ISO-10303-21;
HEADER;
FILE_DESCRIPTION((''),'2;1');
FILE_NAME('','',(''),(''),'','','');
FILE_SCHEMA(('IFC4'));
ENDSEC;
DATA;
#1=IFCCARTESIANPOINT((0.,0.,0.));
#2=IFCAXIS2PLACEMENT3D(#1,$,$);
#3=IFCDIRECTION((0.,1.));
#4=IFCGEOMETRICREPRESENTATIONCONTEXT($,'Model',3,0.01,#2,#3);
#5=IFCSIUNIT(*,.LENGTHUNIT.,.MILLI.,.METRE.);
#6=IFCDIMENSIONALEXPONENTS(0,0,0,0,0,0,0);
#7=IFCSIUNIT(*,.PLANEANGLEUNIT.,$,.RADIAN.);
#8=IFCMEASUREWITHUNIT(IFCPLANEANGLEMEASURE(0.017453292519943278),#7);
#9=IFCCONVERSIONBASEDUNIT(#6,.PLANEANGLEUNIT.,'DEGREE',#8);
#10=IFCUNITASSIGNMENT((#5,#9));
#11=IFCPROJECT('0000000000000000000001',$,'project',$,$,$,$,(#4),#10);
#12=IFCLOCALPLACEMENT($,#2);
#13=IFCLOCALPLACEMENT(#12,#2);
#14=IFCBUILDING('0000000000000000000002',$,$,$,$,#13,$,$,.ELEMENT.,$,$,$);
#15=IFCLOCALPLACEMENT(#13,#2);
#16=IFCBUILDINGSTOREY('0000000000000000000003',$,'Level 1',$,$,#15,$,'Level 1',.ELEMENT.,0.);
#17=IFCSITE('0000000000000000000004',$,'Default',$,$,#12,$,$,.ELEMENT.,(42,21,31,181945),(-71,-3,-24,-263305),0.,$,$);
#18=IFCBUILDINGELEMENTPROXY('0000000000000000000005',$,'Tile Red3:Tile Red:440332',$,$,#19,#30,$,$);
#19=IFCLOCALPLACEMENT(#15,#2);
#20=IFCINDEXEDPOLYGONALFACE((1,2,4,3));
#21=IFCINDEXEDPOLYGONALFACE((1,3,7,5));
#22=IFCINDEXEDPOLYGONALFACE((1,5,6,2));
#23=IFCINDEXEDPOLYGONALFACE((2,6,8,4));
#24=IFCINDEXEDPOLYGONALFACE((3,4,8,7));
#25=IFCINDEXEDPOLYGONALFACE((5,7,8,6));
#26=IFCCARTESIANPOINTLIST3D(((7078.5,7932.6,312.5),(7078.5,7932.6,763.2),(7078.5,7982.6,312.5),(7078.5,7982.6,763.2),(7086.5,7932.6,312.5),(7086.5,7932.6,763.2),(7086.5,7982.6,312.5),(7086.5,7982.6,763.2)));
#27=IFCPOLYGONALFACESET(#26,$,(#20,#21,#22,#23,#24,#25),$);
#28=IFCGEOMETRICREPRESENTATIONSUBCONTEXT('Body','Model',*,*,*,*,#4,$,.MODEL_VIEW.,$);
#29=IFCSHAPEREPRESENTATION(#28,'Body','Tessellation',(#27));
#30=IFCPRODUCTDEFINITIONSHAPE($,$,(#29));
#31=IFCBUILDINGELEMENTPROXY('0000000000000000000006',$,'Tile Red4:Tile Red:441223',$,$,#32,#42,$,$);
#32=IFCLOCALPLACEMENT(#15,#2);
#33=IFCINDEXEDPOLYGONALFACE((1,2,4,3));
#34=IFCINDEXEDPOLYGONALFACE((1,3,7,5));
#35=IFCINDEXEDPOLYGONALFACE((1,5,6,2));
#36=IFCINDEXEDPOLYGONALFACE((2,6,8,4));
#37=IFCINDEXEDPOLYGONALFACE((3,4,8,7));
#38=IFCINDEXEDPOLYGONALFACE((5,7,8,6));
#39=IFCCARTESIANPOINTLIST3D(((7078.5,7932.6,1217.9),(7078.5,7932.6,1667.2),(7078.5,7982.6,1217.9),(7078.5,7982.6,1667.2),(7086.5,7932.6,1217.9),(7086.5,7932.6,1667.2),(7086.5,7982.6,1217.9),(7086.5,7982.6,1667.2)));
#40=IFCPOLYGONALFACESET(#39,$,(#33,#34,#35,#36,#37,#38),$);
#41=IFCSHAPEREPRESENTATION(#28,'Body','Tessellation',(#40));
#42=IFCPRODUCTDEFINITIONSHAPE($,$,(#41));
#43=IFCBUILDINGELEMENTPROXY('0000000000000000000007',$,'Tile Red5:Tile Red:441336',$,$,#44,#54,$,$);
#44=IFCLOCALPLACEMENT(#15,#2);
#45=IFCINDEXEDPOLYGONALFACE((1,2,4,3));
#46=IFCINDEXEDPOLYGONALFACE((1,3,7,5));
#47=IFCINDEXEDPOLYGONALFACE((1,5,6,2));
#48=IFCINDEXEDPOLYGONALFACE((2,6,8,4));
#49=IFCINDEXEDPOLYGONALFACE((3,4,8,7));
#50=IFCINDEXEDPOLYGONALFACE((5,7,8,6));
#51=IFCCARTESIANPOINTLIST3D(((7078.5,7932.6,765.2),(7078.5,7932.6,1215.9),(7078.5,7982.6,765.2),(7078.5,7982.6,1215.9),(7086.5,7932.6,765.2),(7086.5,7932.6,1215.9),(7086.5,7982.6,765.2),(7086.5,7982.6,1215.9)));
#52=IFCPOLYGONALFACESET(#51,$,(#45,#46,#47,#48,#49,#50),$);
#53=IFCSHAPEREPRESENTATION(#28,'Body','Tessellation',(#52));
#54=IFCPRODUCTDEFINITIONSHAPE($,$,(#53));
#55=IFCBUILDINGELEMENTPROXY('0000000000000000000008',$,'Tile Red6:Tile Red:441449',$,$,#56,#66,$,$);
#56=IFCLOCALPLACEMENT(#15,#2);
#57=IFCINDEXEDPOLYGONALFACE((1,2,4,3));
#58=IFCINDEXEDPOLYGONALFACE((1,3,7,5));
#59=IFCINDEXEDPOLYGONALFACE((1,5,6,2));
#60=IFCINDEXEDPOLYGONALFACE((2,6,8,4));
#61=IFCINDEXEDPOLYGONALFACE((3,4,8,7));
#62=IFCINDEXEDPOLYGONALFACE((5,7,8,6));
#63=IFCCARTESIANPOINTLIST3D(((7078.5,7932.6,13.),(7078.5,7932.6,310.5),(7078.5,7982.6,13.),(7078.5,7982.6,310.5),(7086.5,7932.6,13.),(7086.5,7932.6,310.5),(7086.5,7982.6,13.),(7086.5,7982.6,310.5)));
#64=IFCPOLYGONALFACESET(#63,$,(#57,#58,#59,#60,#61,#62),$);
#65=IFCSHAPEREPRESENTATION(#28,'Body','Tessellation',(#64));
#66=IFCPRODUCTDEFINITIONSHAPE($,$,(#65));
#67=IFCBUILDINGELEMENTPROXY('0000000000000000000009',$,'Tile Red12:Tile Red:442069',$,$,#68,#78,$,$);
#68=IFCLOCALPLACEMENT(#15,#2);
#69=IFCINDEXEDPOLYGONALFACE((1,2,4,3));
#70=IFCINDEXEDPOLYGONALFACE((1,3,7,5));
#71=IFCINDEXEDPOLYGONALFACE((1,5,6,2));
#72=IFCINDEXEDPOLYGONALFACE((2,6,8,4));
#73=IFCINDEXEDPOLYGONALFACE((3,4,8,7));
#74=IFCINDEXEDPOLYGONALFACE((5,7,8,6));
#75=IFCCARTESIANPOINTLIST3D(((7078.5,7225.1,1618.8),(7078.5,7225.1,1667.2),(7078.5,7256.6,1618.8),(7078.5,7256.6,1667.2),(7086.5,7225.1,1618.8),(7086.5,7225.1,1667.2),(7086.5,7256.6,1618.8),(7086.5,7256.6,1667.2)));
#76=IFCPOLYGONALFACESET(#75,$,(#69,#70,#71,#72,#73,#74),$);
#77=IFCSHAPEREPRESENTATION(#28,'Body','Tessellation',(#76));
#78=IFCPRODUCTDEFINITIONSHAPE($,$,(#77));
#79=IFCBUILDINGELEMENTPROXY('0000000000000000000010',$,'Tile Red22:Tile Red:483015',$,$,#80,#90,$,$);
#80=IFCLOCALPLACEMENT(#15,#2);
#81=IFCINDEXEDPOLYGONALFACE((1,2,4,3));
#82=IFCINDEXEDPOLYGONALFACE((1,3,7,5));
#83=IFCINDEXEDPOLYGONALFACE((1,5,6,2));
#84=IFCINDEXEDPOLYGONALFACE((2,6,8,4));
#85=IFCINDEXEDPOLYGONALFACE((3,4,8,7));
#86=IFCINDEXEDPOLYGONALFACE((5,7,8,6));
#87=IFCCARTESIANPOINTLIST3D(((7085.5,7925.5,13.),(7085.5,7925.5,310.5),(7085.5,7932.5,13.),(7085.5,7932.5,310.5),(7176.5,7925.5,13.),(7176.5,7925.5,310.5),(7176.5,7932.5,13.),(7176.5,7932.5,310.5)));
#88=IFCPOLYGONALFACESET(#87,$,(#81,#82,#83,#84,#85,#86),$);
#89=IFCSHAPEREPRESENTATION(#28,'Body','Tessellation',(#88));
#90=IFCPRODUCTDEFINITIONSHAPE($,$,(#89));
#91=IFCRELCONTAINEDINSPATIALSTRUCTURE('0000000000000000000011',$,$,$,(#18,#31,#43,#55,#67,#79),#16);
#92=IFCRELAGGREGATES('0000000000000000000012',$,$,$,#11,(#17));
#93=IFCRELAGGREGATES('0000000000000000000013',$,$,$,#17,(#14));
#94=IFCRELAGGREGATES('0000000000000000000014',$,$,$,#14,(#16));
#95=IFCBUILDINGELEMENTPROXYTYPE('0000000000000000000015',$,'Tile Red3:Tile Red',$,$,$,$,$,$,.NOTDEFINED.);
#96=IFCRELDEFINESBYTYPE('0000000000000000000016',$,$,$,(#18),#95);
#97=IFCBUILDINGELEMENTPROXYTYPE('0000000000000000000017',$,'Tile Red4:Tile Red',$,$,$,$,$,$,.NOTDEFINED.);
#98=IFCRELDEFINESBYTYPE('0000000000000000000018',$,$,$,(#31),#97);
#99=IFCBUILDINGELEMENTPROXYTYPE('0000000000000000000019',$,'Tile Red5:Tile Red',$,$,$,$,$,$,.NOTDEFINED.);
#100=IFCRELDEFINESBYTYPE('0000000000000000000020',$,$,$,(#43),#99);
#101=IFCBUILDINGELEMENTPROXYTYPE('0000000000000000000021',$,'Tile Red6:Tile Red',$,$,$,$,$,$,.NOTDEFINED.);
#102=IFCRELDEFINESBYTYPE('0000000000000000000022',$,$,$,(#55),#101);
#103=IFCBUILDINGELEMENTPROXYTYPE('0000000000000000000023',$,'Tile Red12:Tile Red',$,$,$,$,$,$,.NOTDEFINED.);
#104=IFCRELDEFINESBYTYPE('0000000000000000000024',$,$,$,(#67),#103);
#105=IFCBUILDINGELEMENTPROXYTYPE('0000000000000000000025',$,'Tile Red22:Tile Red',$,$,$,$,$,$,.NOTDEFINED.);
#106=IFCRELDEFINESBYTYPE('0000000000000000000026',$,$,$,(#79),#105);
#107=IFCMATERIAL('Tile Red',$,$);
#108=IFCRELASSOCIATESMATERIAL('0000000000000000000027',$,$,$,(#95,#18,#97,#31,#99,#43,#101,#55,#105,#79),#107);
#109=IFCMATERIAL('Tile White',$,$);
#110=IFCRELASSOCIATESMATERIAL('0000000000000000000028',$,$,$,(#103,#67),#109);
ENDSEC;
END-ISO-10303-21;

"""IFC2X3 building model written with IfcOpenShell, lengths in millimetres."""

from ifc_helpers import new_model, entity, si_unit, converted_unit, direction, frame, frame_2d, origin, origin_2d_with_axis, place, context, subcontext, project, spatial, rectangle, extrude, source, transform, mapped, material, type_object, type_shapes, element, save


model = new_model("IFC2X3")

# Units and contexts
model_context = context("Model", 3, precision=0.01, world=origin(), true_north=direction((0.0, 1.0)))
body_context = subcontext(model_context, "Body", "Model", "MODEL_VIEW")
ifc_project = project(units=[si_unit("LENGTHUNIT", "METRE", prefix="MILLI"), converted_unit("PLANEANGLEUNIT", "DEGREE", entity("IfcPlaneAngleMeasure", 0.017453292519943278), si_unit("PLANEANGLEUNIT", "RADIAN"), dimensions=[0, 0, 0, 0, 0, 0, 0])], contexts=[model_context])

# Site, building, storey
site_placement = place(None, origin())
site = spatial("IfcSite", under=ifc_project, at=site_placement, Name="Default", CompositionType="ELEMENT", RefLatitude=(42, 21, 31, 181945), RefLongitude=(-71, -3, -24, -263305), RefElevation=0.0)
building_placement = place(site_placement, origin())
building = spatial("IfcBuilding", under=site, at=building_placement, CompositionType="ELEMENT")
storey_placement = place(building_placement, origin())
storey = spatial("IfcBuildingStorey", under=building, at=storey_placement, Name="Level 1", LongName="Level 1", CompositionType="ELEMENT", Elevation=0.0)

# Building element proxies
ifc_material_1 = material(Name="Tile Red")
building_element_proxy_type_1 = type_object("IfcBuildingElementProxyType", Name="Tile Red3:Tile Red", PredefinedType="NOTDEFINED", material=ifc_material_1)
shared_shape_1 = source(origin(), body_context, "Body", "SweptSolid", [
    extrude(rectangle(XDim=8.0, YDim=50.0, at=origin_2d_with_axis()), frame((7082.5, 7957.6, 312.5)), (0.0, 0.0, 1.0), 450.7),
])
type_shapes(building_element_proxy_type_1, [shared_shape_1])
proxy_1_placement = place(storey_placement, origin())
element("IfcBuildingElementProxy", 1, at=proxy_1_placement, inside=storey, type_object=building_element_proxy_type_1, material=ifc_material_1, Name="Tile Red3:Tile Red:440332", context=body_context, shape_type="MappedRepresentation", body=[
    mapped(shared_shape_1, transform((0.0, 0.0, 0.0), scale=1.0)),
])
building_element_proxy_type_2 = type_object("IfcBuildingElementProxyType", Name="Tile Red4:Tile Red", PredefinedType="NOTDEFINED", material=ifc_material_1)
shared_shape_2 = source(origin(), body_context, "Body", "SweptSolid", [
    extrude(rectangle(XDim=8.0, YDim=50.0, at=origin_2d_with_axis()), frame((7082.5, 7957.6, 1217.9)), (0.0, 0.0, 1.0), 449.3),
])
type_shapes(building_element_proxy_type_2, [shared_shape_2])
proxy_2_placement = place(storey_placement, origin())
element("IfcBuildingElementProxy", 2, at=proxy_2_placement, inside=storey, type_object=building_element_proxy_type_2, material=ifc_material_1, Name="Tile Red4:Tile Red:441223", context=body_context, shape_type="MappedRepresentation", body=[
    mapped(shared_shape_2, transform((0.0, 0.0, 0.0), scale=1.0)),
])
building_element_proxy_type_3 = type_object("IfcBuildingElementProxyType", Name="Tile Red5:Tile Red", PredefinedType="NOTDEFINED", material=ifc_material_1)
shared_shape_3 = source(origin(), body_context, "Body", "SweptSolid", [
    extrude(rectangle(XDim=8.0, YDim=50.0, at=origin_2d_with_axis()), frame((7082.5, 7957.6, 765.2)), (0.0, 0.0, 1.0), 450.7),
])
type_shapes(building_element_proxy_type_3, [shared_shape_3])
proxy_3_placement = place(storey_placement, origin())
element("IfcBuildingElementProxy", 3, at=proxy_3_placement, inside=storey, type_object=building_element_proxy_type_3, material=ifc_material_1, Name="Tile Red5:Tile Red:441336", context=body_context, shape_type="MappedRepresentation", body=[
    mapped(shared_shape_3, transform((0.0, 0.0, 0.0), scale=1.0)),
])
building_element_proxy_type_4 = type_object("IfcBuildingElementProxyType", Name="Tile Red6:Tile Red", PredefinedType="NOTDEFINED", material=ifc_material_1)
shared_shape_4 = source(origin(), body_context, "Body", "SweptSolid", [
    extrude(rectangle(XDim=8.0, YDim=50.0, at=origin_2d_with_axis()), frame((7082.5, 7957.6, 13.0)), (0.0, 0.0, 1.0), 297.5),
])
type_shapes(building_element_proxy_type_4, [shared_shape_4])
proxy_4_placement = place(storey_placement, origin())
element("IfcBuildingElementProxy", 4, at=proxy_4_placement, inside=storey, type_object=building_element_proxy_type_4, material=ifc_material_1, Name="Tile Red6:Tile Red:441449", context=body_context, shape_type="MappedRepresentation", body=[
    mapped(shared_shape_4, transform((0.0, 0.0, 0.0), scale=1.0)),
])
ifc_material_2 = material(Name="Tile White")
building_element_proxy_type_5 = type_object("IfcBuildingElementProxyType", Name="Tile Red12:Tile Red", PredefinedType="NOTDEFINED", material=ifc_material_2)
shared_shape_5 = source(origin(), body_context, "Body", "SweptSolid", [
    extrude(rectangle(XDim=8.0, YDim=31.5, at=frame_2d((0.0, 0.0), x_axis=(1.0, 0.0))), frame((7082.5, 7240.9, 1618.8)), (0.0, 0.0, 1.0), 48.4),
])
type_shapes(building_element_proxy_type_5, [shared_shape_5])
proxy_5_placement = place(storey_placement, origin())
element("IfcBuildingElementProxy", 5, at=proxy_5_placement, inside=storey, type_object=building_element_proxy_type_5, material=ifc_material_2, Name="Tile Red12:Tile Red:442069", context=body_context, shape_type="MappedRepresentation", body=[
    mapped(shared_shape_5, transform((0.0, 0.0, 0.0), scale=1.0)),
])
building_element_proxy_type_6 = type_object("IfcBuildingElementProxyType", Name="Tile Red22:Tile Red", PredefinedType="NOTDEFINED", material=ifc_material_1)
shared_shape_6 = source(origin(), body_context, "Body", "SweptSolid", [
    extrude(rectangle(XDim=7.0, YDim=91.0, at=frame_2d((0.0, 0.0), x_axis=(1.0, 0.0))), frame((7133.0, 7929.2, 0.0), z_axis=(0.0, 0.0, 1.0), x_axis=(0.0, 1.0, 0.0)), (0.0, 0.0, 1.0), 297.5),
])
type_shapes(building_element_proxy_type_6, [shared_shape_6])
proxy_6_placement = place(storey_placement, frame((-2.0, -0.1, 13.0)))
element("IfcBuildingElementProxy", 6, at=proxy_6_placement, inside=storey, type_object=building_element_proxy_type_6, material=ifc_material_1, Name="Tile Red22:Tile Red:483015", context=body_context, shape_type="MappedRepresentation", body=[
    mapped(shared_shape_6, transform((0.0, 0.0, 0.0), scale=1.0)),
])

save(model, "model.ifc")
